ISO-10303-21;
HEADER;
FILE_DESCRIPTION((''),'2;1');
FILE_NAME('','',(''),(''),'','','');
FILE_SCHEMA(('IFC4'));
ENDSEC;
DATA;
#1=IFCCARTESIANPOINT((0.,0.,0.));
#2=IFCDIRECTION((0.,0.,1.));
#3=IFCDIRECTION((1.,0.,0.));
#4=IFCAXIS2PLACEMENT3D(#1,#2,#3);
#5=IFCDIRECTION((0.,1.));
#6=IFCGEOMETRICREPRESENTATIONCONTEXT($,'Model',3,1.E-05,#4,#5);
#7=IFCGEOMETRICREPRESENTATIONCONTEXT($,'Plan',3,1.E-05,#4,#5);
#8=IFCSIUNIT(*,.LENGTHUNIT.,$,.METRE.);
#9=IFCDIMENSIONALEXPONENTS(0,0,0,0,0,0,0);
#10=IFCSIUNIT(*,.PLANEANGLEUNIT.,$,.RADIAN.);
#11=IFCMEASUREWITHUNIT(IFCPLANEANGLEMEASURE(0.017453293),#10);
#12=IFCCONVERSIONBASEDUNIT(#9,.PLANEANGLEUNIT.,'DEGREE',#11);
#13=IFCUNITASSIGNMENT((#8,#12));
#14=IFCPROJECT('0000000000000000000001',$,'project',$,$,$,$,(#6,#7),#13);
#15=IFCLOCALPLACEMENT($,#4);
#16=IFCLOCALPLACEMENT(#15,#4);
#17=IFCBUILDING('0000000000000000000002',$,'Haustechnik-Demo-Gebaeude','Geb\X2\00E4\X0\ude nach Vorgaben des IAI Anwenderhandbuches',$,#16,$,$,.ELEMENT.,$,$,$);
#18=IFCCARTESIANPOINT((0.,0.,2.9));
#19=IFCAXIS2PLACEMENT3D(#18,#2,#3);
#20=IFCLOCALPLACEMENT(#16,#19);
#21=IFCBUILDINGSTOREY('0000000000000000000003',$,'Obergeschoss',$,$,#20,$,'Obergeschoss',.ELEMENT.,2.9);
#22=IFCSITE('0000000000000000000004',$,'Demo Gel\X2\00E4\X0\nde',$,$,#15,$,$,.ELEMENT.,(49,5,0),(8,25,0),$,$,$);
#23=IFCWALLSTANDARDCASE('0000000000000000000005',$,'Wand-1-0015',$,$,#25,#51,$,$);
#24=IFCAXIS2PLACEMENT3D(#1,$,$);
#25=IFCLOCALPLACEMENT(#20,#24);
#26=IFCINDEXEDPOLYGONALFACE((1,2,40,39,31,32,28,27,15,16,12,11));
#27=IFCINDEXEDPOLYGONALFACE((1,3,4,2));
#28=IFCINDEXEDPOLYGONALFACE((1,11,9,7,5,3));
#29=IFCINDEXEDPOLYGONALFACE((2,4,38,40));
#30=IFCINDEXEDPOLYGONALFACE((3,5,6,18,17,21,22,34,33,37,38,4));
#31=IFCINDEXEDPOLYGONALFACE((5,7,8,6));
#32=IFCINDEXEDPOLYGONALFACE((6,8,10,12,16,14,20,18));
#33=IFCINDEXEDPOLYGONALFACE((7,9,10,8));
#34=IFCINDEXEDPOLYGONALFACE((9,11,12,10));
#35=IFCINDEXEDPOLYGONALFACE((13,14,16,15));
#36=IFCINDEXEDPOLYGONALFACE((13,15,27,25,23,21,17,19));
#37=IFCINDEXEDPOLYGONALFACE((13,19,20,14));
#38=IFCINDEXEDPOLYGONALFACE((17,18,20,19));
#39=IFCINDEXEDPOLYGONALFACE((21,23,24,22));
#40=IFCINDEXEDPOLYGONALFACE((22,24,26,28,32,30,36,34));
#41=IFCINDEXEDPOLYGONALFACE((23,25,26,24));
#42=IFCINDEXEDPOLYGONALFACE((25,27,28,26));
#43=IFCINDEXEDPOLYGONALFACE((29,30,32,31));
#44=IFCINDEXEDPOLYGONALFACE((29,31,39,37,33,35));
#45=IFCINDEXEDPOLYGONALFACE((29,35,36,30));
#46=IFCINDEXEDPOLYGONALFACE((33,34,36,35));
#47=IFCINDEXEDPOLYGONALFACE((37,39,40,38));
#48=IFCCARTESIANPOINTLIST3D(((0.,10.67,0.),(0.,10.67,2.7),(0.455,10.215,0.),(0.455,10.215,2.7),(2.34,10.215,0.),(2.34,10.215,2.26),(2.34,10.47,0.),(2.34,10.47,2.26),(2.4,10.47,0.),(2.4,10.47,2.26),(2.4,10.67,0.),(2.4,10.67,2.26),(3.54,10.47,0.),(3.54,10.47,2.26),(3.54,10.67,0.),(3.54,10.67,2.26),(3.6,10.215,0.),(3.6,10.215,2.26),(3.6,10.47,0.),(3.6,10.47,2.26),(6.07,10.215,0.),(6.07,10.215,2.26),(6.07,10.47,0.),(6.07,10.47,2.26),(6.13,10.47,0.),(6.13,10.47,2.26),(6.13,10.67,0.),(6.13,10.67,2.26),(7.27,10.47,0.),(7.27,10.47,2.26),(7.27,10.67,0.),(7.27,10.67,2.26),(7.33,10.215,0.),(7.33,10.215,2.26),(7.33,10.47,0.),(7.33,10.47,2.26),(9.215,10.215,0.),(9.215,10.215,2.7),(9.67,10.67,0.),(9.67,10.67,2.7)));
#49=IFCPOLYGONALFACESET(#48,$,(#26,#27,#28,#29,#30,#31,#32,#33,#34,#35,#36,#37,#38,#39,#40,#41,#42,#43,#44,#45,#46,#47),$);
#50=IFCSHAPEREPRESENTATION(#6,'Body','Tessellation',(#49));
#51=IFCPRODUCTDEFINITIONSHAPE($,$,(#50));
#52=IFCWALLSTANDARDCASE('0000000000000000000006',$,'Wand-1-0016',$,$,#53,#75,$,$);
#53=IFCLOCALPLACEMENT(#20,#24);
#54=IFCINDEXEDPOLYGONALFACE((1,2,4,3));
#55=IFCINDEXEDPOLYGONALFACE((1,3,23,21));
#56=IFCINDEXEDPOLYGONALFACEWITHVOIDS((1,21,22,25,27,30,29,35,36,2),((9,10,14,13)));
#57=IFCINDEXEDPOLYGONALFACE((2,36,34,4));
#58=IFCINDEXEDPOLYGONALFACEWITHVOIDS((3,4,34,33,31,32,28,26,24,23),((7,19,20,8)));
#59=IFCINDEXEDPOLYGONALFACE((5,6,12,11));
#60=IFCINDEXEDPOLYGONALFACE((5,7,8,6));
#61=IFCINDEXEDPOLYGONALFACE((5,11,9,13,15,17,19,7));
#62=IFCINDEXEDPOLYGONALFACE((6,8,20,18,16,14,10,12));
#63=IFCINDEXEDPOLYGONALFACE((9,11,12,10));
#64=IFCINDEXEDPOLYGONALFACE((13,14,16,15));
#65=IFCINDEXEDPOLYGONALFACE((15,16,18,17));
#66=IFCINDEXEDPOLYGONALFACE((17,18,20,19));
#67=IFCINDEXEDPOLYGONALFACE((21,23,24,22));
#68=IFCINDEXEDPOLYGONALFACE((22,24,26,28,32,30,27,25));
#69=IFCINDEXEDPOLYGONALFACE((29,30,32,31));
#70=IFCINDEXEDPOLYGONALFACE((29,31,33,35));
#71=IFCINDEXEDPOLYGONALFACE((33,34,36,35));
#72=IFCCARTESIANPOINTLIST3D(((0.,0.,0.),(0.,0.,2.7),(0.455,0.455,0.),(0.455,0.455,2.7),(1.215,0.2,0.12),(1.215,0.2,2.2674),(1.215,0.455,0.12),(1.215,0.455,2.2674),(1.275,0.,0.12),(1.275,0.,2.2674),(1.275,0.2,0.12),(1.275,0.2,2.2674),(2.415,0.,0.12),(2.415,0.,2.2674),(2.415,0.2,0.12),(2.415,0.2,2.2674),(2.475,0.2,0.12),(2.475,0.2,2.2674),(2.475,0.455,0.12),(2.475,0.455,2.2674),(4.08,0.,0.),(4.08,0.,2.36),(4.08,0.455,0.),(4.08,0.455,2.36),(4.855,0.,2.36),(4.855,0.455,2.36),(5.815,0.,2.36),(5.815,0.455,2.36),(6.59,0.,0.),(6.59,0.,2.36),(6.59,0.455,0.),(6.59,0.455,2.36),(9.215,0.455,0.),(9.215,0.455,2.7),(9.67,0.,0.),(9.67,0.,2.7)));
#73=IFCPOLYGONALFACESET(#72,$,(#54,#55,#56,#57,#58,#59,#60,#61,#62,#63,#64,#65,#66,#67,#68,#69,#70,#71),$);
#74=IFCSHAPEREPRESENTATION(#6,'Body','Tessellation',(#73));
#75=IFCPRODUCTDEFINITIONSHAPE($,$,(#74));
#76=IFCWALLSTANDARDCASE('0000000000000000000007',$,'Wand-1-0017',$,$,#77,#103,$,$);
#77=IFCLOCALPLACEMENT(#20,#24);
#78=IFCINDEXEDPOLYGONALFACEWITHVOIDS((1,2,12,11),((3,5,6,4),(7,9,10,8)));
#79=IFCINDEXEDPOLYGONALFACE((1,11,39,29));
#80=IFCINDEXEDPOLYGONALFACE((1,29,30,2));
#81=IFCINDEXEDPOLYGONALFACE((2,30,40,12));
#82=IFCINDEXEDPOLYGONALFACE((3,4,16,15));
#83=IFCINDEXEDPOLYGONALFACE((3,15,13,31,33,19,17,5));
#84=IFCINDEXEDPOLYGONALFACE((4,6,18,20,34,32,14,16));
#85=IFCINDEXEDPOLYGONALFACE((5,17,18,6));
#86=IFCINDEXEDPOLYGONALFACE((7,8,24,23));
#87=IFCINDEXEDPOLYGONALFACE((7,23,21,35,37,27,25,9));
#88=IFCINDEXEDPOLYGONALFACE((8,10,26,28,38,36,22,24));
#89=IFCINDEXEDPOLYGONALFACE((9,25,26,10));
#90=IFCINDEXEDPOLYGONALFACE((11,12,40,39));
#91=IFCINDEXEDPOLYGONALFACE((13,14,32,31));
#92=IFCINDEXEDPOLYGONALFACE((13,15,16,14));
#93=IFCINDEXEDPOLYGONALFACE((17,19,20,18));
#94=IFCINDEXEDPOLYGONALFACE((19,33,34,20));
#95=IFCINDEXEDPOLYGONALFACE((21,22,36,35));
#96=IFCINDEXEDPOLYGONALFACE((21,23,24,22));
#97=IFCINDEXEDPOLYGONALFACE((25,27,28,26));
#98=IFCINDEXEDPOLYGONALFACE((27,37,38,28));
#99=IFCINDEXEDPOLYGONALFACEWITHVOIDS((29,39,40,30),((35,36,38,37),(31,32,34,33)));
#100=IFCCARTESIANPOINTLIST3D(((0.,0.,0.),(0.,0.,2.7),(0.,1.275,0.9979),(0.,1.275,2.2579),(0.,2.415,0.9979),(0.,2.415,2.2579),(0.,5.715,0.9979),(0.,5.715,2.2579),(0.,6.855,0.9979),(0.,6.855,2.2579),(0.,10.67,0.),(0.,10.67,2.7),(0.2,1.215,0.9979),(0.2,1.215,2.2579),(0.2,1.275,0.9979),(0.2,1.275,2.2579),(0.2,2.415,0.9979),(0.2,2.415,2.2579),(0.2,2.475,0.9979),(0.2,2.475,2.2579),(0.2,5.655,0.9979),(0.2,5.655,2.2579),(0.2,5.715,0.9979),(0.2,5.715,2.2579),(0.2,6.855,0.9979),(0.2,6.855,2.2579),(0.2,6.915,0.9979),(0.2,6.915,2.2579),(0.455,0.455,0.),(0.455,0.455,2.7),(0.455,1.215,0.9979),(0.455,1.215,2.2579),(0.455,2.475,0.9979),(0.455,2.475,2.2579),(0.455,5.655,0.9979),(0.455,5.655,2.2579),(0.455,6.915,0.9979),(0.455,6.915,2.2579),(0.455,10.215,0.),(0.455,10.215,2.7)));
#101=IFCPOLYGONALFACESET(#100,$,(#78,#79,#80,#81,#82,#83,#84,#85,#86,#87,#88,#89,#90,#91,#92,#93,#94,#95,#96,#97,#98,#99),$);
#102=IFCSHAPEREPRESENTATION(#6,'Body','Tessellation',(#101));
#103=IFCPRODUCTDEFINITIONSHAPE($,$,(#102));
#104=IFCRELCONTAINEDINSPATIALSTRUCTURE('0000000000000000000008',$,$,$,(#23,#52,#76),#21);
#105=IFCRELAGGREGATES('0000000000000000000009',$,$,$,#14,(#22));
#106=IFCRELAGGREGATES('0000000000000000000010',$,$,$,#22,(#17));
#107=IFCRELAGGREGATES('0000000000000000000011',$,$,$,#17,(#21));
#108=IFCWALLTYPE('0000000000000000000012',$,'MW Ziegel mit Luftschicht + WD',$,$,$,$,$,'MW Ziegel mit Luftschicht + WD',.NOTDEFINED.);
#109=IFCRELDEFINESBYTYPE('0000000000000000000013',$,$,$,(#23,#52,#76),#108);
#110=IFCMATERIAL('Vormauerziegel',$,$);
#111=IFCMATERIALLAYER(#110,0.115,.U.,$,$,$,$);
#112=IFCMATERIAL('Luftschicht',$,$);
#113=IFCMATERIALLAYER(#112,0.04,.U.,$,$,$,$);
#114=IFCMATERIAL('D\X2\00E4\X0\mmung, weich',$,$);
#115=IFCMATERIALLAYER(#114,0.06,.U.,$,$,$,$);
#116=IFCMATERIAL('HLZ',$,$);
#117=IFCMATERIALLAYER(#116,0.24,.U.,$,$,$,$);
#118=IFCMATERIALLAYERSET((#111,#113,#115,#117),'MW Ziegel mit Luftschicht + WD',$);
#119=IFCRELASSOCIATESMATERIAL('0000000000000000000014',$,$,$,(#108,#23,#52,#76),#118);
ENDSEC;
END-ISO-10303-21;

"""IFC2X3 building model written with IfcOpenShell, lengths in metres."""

from ifc_helpers import new_model, entity, si_unit, converted_unit, direction, frame, origin_with_axes, place, context, project, spatial, polyline, outline, extrude, material, layer, layer_set, layer_usage, type_object, element, save


model = new_model("IFC2X3")

# Units and contexts
model_context = context("Model", 3, precision=1e-05, world=origin_with_axes(), true_north=direction((0.0, 1.0)))
plan_context = context("Plan", 3, precision=1e-05, world=origin_with_axes(), true_north=direction((0.0, 1.0)))
ifc_project = project(units=[si_unit("LENGTHUNIT", "METRE"), converted_unit("PLANEANGLEUNIT", "DEGREE", entity("IfcPlaneAngleMeasure", 0.017453293), si_unit("PLANEANGLEUNIT", "RADIAN"), dimensions=[0, 0, 0, 0, 0, 0, 0])], contexts=[model_context, plan_context])

# Site, building, storey
site_placement = place(None, origin_with_axes())
site = spatial("IfcSite", under=ifc_project, at=site_placement, Name="Demo Gelände", CompositionType="ELEMENT", RefLatitude=(49, 5, 0), RefLongitude=(8, 25, 0))
building_placement = place(site_placement, origin_with_axes())
building = spatial("IfcBuilding", under=site, at=building_placement, Name="Haustechnik-Demo-Gebaeude", Description="Gebäude nach Vorgaben des IAI Anwenderhandbuches", CompositionType="ELEMENT")
storey_placement = place(building_placement, frame((0.0, 0.0, 2.9), z_axis=(0.0, 0.0, 1.0), x_axis=(1.0, 0.0, 0.0)))
storey = spatial("IfcBuildingStorey", under=building, at=storey_placement, Name="Obergeschoss", LongName="Obergeschoss", CompositionType="ELEMENT", Elevation=2.9)

# Walls, openings
ifc_material_1 = material(Name="Vormauerziegel")
ifc_layer_1 = layer(ifc_material_1, 0.115, ventilated="UNKNOWN")
ifc_material_2 = material(Name="Luftschicht")
ifc_layer_2 = layer(ifc_material_2, 0.04, ventilated="UNKNOWN")
ifc_material_3 = material(Name="Dämmung, weich")
ifc_layer_3 = layer(ifc_material_3, 0.06, ventilated="UNKNOWN")
ifc_material_4 = material(Name="HLZ")
ifc_layer_4 = layer(ifc_material_4, 0.24, ventilated="UNKNOWN")
ifc_layer_set_1 = layer_set([ifc_layer_1, ifc_layer_2, ifc_layer_3, ifc_layer_4], Name="MW Ziegel mit Luftschicht + WD")
wall_type_1 = type_object("IfcWallType", Name="MW Ziegel mit Luftschicht + WD", ElementType="MW Ziegel mit Luftschicht + WD", PredefinedType="NOTDEFINED", material=ifc_layer_set_1)
ifc_layer_usage_1 = layer_usage(ifc_layer_set_1, "AXIS2", "NEGATIVE", 0.0)
wall_1_placement = place(storey_placement, frame((0.0, 10.67, 0.0), z_axis=(0.0, 0.0, 1.0), x_axis=(1.0, 0.0, 0.0)))
wall_1 = element("IfcWallStandardCase", 1, at=wall_1_placement, inside=storey, type_object=wall_type_1, material=ifc_layer_usage_1, Name="Wand-1-0015", context=model_context, shape_type="SweptSolid", body=[
    extrude(outline(polyline([(0.455, -0.455), (9.215, -0.455), (9.67, 0.0), (0.0, 0.0), (0.455, -0.455)])), origin_with_axes(), (0.0, 0.0, 1.0), 2.7),
])
opening_1_placement = place(wall_1_placement, frame((2.97, -0.455, 0.0), z_axis=(0.0, 0.0, 1.0), x_axis=(1.0, 0.0, 0.0)))
element("IfcOpeningElement", 2, at=opening_1_placement, cuts=wall_1, ObjectType="Opening", context=model_context, shape_type="SweptSolid", body=[
    extrude(outline(polyline([(-0.63, 0.0), (0.63, 0.0), (0.63, 0.255), (0.57, 0.255), (0.57, 0.455), (-0.57, 0.455), (-0.57, 0.255), (-0.63, 0.255), (-0.63, 0.0)])), origin_with_axes(), (0.0, 0.0, 1.0), 2.26),
])
opening_2_placement = place(wall_1_placement, frame((6.7, -0.455, 0.0), z_axis=(0.0, 0.0, 1.0), x_axis=(1.0, 0.0, 0.0)))
element("IfcOpeningElement", 3, at=opening_2_placement, cuts=wall_1, ObjectType="Opening", context=model_context, shape_type="SweptSolid", body=[
    extrude(outline(polyline([(-0.63, 0.0), (0.63, 0.0), (0.63, 0.255), (0.57, 0.255), (0.57, 0.455), (-0.57, 0.455), (-0.57, 0.255), (-0.63, 0.255), (-0.63, 0.0)])), origin_with_axes(), (0.0, 0.0, 1.0), 2.26),
])
ifc_layer_usage_2 = layer_usage(ifc_layer_set_1, "AXIS2", "POSITIVE", 0.0)
wall_2_placement = place(storey_placement, origin_with_axes())
wall_2 = element("IfcWallStandardCase", 4, at=wall_2_placement, inside=storey, type_object=wall_type_1, material=ifc_layer_usage_2, Name="Wand-1-0016", context=model_context, shape_type="SweptSolid", body=[
    extrude(outline(polyline([(0.0, 0.0), (9.67, 0.0), (9.215, 0.455), (0.455, 0.455), (0.0, 0.0)])), origin_with_axes(), (0.0, 0.0, 1.0), 2.7),
])
opening_3_placement = place(wall_2_placement, frame((1.845, 0.0, 0.12), z_axis=(0.0, 0.0, 1.0), x_axis=(1.0, 0.0, 0.0)))
element("IfcOpeningElement", 5, at=opening_3_placement, cuts=wall_2, ObjectType="Opening", context=model_context, shape_type="SweptSolid", body=[
    extrude(outline(polyline([(-0.57, 0.0), (0.57, 0.0), (0.57, 0.2), (0.63, 0.2), (0.63, 0.455), (-0.63, 0.455), (-0.63, 0.2), (-0.57, 0.2), (-0.57, 0.0)])), origin_with_axes(), (0.0, 0.0, 1.0), 2.1474),
])
opening_4_placement = place(wall_2_placement, frame((6.2025, 0.0, -0.2), z_axis=(0.0, 0.0, 1.0), x_axis=(1.0, 0.0, 0.0)))
element("IfcOpeningElement", 6, at=opening_4_placement, cuts=wall_2, ObjectType="Opening", context=model_context, shape_type="SweptSolid", body=[
    extrude(outline(polyline([(-0.3875, 0.0), (0.3875, 0.0), (0.3875, 2.56), (-0.3875, 2.56), (-0.3875, 0.0)])), frame((0.0, 0.0, 0.0), z_axis=(0.0, 1.0, 0.0), x_axis=(-1.0, 0.0, 0.0)), (0.0, 0.0, 1.0), 0.455),
])
opening_5_placement = place(wall_2_placement, frame((5.335, 0.0, -0.2), z_axis=(0.0, 0.0, 1.0), x_axis=(1.0, 0.0, 0.0)))
element("IfcOpeningElement", 7, at=opening_5_placement, cuts=wall_2, ObjectType="Opening", context=model_context, shape_type="SweptSolid", body=[
    extrude(outline(polyline([(-0.48, 0.0), (0.48, 0.0), (0.48, 2.56), (-0.48, 2.56), (-0.48, 0.0)])), frame((0.0, 0.0, 0.0), z_axis=(0.0, 1.0, 0.0), x_axis=(-1.0, 0.0, 0.0)), (0.0, 0.0, 1.0), 0.455),
])
opening_6_placement = place(wall_2_placement, frame((4.4675, 0.0, -0.2), z_axis=(0.0, 0.0, 1.0), x_axis=(1.0, 0.0, 0.0)))
element("IfcOpeningElement", 8, at=opening_6_placement, cuts=wall_2, ObjectType="Opening", context=model_context, shape_type="SweptSolid", body=[
    extrude(outline(polyline([(-0.3875, 0.0), (0.3875, 0.0), (0.3875, 2.56), (-0.3875, 2.56), (-0.3875, 0.0)])), frame((0.0, 0.0, 0.0), z_axis=(0.0, 1.0, 0.0), x_axis=(-1.0, 0.0, 0.0)), (0.0, 0.0, 1.0), 0.455),
])
ifc_layer_usage_3 = layer_usage(ifc_layer_set_1, "AXIS2", "POSITIVE", 0.0)
wall_3_placement = place(storey_placement, frame((0.0, 10.67, 0.0), z_axis=(0.0, 0.0, 1.0), x_axis=(0.0, -1.0, 0.0)))
wall_3 = element("IfcWallStandardCase", 9, at=wall_3_placement, inside=storey, type_object=wall_type_1, material=ifc_layer_usage_3, Name="Wand-1-0017", context=model_context, shape_type="SweptSolid", body=[
    extrude(outline(polyline([(0.0, 0.0), (10.67, 0.0), (10.215, 0.455), (0.455, 0.455), (0.0, 0.0)])), origin_with_axes(), (0.0, 0.0, 1.0), 2.7),
])
opening_7_placement = place(wall_3_placement, frame((4.385, 0.0, 0.9979), z_axis=(0.0, 0.0, 1.0), x_axis=(1.0, 0.0, 0.0)))
element("IfcOpeningElement", 10, at=opening_7_placement, cuts=wall_3, ObjectType="Opening", context=model_context, shape_type="SweptSolid", body=[
    extrude(outline(polyline([(-0.57, 0.0), (0.57, 0.0), (0.57, 0.2), (0.63, 0.2), (0.63, 0.455), (-0.63, 0.455), (-0.63, 0.2), (-0.57, 0.2), (-0.57, 0.0)])), origin_with_axes(), (0.0, 0.0, 1.0), 1.26),
])
opening_8_placement = place(wall_3_placement, frame((8.825, 0.0, 0.9979), z_axis=(0.0, 0.0, 1.0), x_axis=(1.0, 0.0, 0.0)))
element("IfcOpeningElement", 11, at=opening_8_placement, cuts=wall_3, ObjectType="Opening", context=model_context, shape_type="SweptSolid", body=[
    extrude(outline(polyline([(-0.57, 0.0), (0.57, 0.0), (0.57, 0.2), (0.63, 0.2), (0.63, 0.455), (-0.63, 0.455), (-0.63, 0.2), (-0.57, 0.2), (-0.57, 0.0)])), origin_with_axes(), (0.0, 0.0, 1.0), 1.26),
])

save(model, "model.ifc")
